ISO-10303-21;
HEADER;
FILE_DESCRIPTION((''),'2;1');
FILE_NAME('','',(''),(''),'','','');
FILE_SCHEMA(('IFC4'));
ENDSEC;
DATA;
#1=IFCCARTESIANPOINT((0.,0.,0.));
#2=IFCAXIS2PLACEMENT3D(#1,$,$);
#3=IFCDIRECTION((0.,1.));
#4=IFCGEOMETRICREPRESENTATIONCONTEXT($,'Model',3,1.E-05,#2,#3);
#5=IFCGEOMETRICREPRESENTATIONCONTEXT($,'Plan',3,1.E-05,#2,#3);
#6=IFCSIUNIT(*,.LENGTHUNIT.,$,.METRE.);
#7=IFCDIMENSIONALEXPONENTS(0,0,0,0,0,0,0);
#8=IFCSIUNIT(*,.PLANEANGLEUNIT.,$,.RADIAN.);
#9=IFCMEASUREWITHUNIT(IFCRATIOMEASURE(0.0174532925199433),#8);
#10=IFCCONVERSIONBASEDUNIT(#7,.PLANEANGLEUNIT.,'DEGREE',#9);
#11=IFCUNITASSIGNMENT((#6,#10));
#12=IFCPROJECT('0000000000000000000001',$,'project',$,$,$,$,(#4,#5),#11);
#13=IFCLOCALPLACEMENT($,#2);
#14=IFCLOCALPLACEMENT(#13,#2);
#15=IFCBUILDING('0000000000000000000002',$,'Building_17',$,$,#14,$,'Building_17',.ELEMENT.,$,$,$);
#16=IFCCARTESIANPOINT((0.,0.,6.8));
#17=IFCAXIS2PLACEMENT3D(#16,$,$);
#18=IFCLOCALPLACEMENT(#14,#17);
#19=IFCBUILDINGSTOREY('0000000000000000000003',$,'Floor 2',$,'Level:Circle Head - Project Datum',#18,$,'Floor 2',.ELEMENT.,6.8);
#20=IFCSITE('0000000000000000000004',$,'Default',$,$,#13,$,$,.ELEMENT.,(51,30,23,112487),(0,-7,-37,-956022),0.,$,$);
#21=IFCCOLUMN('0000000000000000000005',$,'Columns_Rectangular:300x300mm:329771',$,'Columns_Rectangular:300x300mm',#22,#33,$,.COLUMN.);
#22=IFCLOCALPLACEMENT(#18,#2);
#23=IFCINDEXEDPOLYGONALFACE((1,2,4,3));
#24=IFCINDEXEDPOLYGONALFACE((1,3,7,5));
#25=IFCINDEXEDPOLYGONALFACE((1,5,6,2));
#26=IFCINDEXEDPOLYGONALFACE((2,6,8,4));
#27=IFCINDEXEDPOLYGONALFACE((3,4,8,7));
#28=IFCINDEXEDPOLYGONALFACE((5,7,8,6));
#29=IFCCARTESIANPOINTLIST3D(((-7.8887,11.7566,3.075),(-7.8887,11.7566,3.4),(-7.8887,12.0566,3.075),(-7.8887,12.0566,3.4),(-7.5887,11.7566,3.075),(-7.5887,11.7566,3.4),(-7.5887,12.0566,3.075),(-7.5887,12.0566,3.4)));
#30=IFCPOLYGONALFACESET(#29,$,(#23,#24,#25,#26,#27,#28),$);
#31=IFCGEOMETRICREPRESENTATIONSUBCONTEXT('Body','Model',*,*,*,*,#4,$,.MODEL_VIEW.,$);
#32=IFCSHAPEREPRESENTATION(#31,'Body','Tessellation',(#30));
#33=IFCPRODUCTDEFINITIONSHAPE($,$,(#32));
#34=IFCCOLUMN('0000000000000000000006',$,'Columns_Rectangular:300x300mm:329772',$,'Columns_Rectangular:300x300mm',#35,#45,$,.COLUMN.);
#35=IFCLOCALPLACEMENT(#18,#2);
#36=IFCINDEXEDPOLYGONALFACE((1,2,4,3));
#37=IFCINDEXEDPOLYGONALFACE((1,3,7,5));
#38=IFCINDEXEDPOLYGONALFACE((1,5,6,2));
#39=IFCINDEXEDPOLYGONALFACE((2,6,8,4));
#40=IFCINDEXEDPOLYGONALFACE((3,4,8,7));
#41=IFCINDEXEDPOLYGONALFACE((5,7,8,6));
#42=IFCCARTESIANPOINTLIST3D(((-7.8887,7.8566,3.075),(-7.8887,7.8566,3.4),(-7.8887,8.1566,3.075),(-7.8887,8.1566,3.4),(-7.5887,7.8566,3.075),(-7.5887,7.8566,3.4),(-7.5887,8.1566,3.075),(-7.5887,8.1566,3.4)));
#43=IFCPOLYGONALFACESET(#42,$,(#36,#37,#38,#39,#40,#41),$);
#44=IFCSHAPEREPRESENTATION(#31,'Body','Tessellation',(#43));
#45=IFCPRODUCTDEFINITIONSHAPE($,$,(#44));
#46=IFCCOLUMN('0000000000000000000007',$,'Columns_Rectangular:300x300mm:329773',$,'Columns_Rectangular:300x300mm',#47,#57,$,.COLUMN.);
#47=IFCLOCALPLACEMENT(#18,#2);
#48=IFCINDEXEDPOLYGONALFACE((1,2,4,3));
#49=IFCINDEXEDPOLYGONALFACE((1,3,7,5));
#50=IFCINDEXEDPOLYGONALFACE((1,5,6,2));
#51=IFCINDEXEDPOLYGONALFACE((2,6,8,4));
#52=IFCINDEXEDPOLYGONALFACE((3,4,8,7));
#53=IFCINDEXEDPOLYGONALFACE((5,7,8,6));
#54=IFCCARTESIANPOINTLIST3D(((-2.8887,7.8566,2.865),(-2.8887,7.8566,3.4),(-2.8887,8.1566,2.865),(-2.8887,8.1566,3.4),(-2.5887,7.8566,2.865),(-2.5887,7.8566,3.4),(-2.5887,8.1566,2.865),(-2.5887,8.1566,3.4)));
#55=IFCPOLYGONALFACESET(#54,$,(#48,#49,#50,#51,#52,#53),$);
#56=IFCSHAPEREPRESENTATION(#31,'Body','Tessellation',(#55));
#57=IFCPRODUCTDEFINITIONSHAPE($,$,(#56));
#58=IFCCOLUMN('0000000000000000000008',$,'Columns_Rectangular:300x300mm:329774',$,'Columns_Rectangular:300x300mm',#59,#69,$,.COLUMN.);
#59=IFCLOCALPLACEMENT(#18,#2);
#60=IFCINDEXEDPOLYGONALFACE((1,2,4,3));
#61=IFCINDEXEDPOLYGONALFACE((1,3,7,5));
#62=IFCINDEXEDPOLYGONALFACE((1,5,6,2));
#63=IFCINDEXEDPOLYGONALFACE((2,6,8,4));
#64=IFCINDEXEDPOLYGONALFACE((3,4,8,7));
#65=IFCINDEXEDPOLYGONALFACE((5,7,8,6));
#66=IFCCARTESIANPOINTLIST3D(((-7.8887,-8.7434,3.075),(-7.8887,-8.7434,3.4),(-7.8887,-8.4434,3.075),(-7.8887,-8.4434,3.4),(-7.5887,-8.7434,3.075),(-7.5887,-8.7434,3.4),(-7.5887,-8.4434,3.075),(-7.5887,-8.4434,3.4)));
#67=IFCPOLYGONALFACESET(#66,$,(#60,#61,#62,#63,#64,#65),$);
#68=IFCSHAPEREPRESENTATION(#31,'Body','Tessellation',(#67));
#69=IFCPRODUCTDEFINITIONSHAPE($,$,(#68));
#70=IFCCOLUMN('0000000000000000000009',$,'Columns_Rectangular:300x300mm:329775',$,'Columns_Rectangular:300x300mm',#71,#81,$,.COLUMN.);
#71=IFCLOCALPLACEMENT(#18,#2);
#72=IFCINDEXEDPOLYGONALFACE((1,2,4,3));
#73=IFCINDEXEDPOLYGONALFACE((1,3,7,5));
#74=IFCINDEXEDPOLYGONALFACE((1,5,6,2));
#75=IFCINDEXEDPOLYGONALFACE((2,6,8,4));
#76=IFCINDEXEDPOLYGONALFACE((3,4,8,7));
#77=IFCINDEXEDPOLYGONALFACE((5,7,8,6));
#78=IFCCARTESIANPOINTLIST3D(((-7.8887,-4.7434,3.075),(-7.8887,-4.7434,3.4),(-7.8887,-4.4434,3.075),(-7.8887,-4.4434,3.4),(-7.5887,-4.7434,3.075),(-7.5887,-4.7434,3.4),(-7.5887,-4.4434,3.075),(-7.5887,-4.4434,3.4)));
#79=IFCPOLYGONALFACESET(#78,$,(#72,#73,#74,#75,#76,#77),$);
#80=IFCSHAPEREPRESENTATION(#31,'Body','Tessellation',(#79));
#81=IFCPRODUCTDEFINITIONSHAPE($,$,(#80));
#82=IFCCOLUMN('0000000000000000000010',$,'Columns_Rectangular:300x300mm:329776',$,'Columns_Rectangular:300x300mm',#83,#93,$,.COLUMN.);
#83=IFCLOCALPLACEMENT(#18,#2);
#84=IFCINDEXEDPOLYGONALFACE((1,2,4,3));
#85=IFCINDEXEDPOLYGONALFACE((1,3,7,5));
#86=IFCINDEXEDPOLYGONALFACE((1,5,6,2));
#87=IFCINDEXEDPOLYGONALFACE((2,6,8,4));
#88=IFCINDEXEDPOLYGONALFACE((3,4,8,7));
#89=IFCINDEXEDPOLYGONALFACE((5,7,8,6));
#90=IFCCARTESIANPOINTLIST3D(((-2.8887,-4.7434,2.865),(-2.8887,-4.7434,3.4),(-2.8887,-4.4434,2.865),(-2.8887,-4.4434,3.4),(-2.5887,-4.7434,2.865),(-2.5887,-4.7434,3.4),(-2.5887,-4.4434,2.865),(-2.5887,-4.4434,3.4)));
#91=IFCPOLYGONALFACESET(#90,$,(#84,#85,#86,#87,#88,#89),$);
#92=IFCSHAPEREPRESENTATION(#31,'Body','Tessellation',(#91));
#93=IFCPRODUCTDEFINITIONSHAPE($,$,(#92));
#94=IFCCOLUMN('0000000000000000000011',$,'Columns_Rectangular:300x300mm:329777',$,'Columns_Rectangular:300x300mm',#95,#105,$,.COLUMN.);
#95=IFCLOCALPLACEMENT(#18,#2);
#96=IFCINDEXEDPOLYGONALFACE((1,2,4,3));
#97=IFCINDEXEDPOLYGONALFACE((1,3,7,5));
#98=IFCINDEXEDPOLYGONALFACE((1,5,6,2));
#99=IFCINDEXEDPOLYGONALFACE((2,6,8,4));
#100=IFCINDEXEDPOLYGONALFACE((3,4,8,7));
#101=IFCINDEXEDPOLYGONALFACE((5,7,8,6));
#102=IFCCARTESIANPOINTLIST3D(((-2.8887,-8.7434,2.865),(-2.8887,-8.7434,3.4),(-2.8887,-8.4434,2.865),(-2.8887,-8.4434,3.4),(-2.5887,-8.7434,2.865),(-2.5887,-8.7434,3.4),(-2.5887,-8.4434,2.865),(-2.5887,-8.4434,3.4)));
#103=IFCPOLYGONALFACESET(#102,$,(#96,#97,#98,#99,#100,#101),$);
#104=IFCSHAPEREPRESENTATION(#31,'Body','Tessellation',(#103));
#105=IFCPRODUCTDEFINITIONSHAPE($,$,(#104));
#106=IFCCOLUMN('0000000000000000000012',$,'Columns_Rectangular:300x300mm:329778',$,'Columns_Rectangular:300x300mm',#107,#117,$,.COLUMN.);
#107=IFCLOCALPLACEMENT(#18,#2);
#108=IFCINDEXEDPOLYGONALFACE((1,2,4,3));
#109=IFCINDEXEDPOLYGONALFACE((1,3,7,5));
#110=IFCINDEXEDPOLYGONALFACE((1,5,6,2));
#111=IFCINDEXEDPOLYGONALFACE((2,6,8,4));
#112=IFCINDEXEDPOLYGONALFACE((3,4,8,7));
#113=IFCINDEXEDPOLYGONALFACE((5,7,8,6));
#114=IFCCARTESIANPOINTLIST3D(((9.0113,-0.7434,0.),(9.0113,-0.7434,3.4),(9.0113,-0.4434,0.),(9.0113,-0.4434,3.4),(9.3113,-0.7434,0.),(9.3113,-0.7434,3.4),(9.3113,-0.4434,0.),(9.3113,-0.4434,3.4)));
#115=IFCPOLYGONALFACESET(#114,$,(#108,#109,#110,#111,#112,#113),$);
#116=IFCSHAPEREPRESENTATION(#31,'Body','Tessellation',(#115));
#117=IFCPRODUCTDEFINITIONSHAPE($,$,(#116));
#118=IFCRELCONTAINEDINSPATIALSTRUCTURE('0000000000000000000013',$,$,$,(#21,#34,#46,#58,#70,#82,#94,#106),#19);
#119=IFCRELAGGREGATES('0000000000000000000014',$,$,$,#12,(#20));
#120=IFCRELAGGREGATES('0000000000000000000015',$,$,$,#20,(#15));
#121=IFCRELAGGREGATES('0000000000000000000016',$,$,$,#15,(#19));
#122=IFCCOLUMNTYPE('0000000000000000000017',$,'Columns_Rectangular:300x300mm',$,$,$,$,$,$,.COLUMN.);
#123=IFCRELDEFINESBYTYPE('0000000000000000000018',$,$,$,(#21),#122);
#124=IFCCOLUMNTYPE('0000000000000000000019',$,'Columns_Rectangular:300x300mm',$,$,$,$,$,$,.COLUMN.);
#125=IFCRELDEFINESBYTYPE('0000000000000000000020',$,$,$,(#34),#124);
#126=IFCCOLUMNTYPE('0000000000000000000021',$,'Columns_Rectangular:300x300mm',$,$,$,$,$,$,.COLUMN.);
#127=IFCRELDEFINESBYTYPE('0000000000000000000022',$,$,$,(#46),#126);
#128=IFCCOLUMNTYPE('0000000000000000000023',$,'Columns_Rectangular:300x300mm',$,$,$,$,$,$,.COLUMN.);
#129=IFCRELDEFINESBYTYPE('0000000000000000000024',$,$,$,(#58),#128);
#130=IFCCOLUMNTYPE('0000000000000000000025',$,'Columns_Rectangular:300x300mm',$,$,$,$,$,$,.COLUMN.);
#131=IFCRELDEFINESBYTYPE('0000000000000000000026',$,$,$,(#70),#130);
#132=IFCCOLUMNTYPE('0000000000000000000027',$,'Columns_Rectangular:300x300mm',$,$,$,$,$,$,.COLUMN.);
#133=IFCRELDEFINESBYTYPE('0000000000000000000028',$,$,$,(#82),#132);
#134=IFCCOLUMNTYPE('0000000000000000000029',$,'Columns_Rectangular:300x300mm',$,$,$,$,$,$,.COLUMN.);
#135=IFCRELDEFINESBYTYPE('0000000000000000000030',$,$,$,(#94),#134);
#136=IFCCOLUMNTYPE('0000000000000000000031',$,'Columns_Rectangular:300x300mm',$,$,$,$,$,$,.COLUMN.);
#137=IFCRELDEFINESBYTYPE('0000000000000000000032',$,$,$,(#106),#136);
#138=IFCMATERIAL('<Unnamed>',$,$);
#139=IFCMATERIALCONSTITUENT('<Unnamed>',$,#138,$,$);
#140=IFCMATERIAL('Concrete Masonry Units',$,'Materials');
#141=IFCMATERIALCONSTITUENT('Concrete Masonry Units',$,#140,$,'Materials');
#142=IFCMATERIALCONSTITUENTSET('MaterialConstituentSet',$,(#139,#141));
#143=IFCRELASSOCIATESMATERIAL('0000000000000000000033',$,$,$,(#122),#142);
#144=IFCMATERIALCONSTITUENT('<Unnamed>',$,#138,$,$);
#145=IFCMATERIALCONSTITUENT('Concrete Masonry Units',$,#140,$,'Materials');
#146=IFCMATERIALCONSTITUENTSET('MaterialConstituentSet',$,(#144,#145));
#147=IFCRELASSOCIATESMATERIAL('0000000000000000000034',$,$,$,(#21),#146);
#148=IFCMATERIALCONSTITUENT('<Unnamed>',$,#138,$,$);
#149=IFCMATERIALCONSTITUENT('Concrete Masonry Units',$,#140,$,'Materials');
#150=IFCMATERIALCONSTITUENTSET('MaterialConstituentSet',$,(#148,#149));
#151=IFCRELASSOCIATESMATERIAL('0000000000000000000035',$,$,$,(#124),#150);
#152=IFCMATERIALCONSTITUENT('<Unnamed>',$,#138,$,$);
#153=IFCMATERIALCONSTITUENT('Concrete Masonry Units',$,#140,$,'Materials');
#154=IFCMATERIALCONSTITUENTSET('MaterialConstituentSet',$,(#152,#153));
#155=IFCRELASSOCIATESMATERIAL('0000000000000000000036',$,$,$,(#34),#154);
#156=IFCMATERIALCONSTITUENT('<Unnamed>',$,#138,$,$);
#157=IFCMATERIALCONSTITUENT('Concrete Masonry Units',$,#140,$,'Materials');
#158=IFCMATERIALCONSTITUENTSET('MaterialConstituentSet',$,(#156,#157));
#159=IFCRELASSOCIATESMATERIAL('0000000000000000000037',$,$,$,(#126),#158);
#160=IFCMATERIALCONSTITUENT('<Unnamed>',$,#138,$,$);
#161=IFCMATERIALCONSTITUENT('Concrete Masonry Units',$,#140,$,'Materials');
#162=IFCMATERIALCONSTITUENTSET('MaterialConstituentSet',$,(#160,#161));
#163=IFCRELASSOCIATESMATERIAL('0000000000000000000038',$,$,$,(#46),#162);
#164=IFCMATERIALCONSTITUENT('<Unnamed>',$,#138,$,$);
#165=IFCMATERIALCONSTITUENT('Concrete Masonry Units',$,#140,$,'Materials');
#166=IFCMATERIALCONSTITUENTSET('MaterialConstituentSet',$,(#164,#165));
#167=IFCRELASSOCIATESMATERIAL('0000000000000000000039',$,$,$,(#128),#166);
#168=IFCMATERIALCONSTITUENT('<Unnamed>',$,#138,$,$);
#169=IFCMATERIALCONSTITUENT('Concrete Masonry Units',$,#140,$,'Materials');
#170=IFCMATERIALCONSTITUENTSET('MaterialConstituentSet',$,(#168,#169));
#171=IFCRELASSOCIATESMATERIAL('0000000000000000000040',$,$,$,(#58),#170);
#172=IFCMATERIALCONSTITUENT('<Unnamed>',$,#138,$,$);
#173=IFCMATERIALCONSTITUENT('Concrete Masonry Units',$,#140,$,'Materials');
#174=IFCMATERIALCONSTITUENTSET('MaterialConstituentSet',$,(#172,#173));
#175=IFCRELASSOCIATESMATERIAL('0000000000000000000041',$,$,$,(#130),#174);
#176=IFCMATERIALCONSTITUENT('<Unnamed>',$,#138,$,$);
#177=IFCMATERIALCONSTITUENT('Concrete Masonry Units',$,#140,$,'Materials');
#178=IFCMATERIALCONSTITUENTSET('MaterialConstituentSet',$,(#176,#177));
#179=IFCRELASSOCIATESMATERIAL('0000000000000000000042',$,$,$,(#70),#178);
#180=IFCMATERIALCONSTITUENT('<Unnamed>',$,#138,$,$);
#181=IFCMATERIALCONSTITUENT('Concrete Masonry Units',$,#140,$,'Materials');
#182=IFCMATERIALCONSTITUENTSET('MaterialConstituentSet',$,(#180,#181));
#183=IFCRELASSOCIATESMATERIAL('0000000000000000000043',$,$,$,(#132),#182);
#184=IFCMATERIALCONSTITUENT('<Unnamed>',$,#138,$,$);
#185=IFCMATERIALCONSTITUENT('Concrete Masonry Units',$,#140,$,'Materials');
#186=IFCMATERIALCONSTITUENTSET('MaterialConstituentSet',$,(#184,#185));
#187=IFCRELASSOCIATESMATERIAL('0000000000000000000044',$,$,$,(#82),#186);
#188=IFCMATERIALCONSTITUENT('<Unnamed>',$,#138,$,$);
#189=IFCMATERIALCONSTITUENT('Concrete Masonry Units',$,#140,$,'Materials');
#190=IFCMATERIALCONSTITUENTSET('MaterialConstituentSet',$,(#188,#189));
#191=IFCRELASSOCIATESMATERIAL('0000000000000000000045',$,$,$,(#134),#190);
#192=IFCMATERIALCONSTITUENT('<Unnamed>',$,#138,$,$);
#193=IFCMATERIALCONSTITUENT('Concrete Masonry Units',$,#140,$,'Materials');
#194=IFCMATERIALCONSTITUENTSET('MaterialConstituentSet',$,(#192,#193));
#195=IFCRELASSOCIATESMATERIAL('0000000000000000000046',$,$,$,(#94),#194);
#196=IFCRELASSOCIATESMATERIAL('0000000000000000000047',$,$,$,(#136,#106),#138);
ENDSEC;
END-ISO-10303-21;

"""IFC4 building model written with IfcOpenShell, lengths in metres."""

from ifc_helpers import new_model, entity, si_unit, converted_unit, direction, frame, origin, place, context, subcontext, project, spatial, indexed_curve, outline, extrude, source, transform, mapped, material, constituent, constituent_set, type_object, type_shapes, element, save


model = new_model("IFC4")

# Units and contexts
model_context = context("Model", 3, precision=1e-05, world=origin(), true_north=direction((0.0, 1.0)))
plan_context = context("Plan", 3, precision=1e-05, world=origin(), true_north=direction((0.0, 1.0)))
body_context = subcontext(model_context, "Body", "Model", "MODEL_VIEW")
ifc_project = project(units=[si_unit("LENGTHUNIT", "METRE"), converted_unit("PLANEANGLEUNIT", "DEGREE", entity("IfcRatioMeasure", 0.0174532925199433), si_unit("PLANEANGLEUNIT", "RADIAN"), dimensions=[0, 0, 0, 0, 0, 0, 0])], contexts=[model_context, plan_context])

# Site, building, storey
site_placement = place(None, origin())
site = spatial("IfcSite", under=ifc_project, at=site_placement, Name="Default", CompositionType="ELEMENT", RefLatitude=(51, 30, 23, 112487), RefLongitude=(0, -7, -37, -956022), RefElevation=0.0)
building_placement = place(site_placement, origin())
building = spatial("IfcBuilding", under=site, at=building_placement, Name="Building_17", LongName="Building_17", CompositionType="ELEMENT")
storey_placement = place(building_placement, frame((0.0, 0.0, 6.8)))
storey = spatial("IfcBuildingStorey", under=building, at=storey_placement, Name="Floor 2", ObjectType="Level:Circle Head - Project Datum", LongName="Floor 2", CompositionType="ELEMENT", Elevation=6.8)

# Columns
ifc_material_1 = material(Name="<Unnamed>")
ifc_material_2 = material(Name="Concrete Masonry Units", Category="Materials")
ifc_constituent_1 = constituent(ifc_material_1, Name="<Unnamed>")
ifc_constituent_2 = constituent(ifc_material_2, Name="Concrete Masonry Units", Category="Materials")
ifc_constituent_set_1 = constituent_set(constituents=[ifc_constituent_1, ifc_constituent_2], Name="MaterialConstituentSet")
ifc_constituent_3 = constituent(ifc_material_1, Name="<Unnamed>")
ifc_constituent_4 = constituent(ifc_material_2, Name="Concrete Masonry Units", Category="Materials")
ifc_constituent_set_2 = constituent_set(constituents=[ifc_constituent_3, ifc_constituent_4], Name="MaterialConstituentSet")
column_type_1 = type_object("IfcColumnType", Name="Columns_Rectangular:300x300mm", PredefinedType="COLUMN", material=ifc_constituent_set_2)
shared_shape_1 = source(origin(), body_context, "Body", "SweptSolid", [
    extrude(outline(indexed_curve([(-0.15, -0.15), (0.15, -0.15), (0.15, 0.15), (-0.15, 0.15), (-0.15, -0.15)], self_intersect=False)), frame((-7.7387, 11.9066, 9.875), z_axis=(0.0, 0.0, 1.0), x_axis=(0.0, -1.0, 0.0)), (0.0, 0.0, 1.0), 0.325),
])
type_shapes(column_type_1, [shared_shape_1])
column_1_placement = place(storey_placement, frame((0.0, 0.0, -6.8)))
element("IfcColumn", 1, at=column_1_placement, inside=storey, type_object=column_type_1, material=ifc_constituent_set_1, Name="Columns_Rectangular:300x300mm:329771", ObjectType="Columns_Rectangular:300x300mm", PredefinedType="COLUMN", context=body_context, shape_type="MappedRepresentation", body=[
    mapped(shared_shape_1, transform((0.0, 0.0, 0.0), scale=1.0)),
])
ifc_constituent_5 = constituent(ifc_material_1, Name="<Unnamed>")
ifc_constituent_6 = constituent(ifc_material_2, Name="Concrete Masonry Units", Category="Materials")
ifc_constituent_set_3 = constituent_set(constituents=[ifc_constituent_5, ifc_constituent_6], Name="MaterialConstituentSet")
ifc_constituent_7 = constituent(ifc_material_1, Name="<Unnamed>")
ifc_constituent_8 = constituent(ifc_material_2, Name="Concrete Masonry Units", Category="Materials")
ifc_constituent_set_4 = constituent_set(constituents=[ifc_constituent_7, ifc_constituent_8], Name="MaterialConstituentSet")
column_type_2 = type_object("IfcColumnType", Name="Columns_Rectangular:300x300mm", PredefinedType="COLUMN", material=ifc_constituent_set_4)
shared_shape_2 = source(origin(), body_context, "Body", "SweptSolid", [
    extrude(outline(indexed_curve([(-0.15, -0.15), (0.15, -0.15), (0.15, 0.15), (-0.15, 0.15), (-0.15, -0.15)], self_intersect=False)), frame((-7.7387, 8.0066, 9.875), z_axis=(0.0, 0.0, 1.0), x_axis=(0.0, -1.0, 0.0)), (0.0, 0.0, 1.0), 0.325),
])
type_shapes(column_type_2, [shared_shape_2])
column_2_placement = place(storey_placement, frame((0.0, 0.0, -6.8)))
element("IfcColumn", 2, at=column_2_placement, inside=storey, type_object=column_type_2, material=ifc_constituent_set_3, Name="Columns_Rectangular:300x300mm:329772", ObjectType="Columns_Rectangular:300x300mm", PredefinedType="COLUMN", context=body_context, shape_type="MappedRepresentation", body=[
    mapped(shared_shape_2, transform((0.0, 0.0, 0.0), scale=1.0)),
])
ifc_constituent_9 = constituent(ifc_material_1, Name="<Unnamed>")
ifc_constituent_10 = constituent(ifc_material_2, Name="Concrete Masonry Units", Category="Materials")
ifc_constituent_set_5 = constituent_set(constituents=[ifc_constituent_9, ifc_constituent_10], Name="MaterialConstituentSet")
ifc_constituent_11 = constituent(ifc_material_1, Name="<Unnamed>")
ifc_constituent_12 = constituent(ifc_material_2, Name="Concrete Masonry Units", Category="Materials")
ifc_constituent_set_6 = constituent_set(constituents=[ifc_constituent_11, ifc_constituent_12], Name="MaterialConstituentSet")
column_type_3 = type_object("IfcColumnType", Name="Columns_Rectangular:300x300mm", PredefinedType="COLUMN", material=ifc_constituent_set_6)
shared_shape_3 = source(origin(), body_context, "Body", "SweptSolid", [
    extrude(outline(indexed_curve([(-0.15, -0.15), (0.15, -0.15), (0.15, 0.15), (-0.15, 0.15), (-0.15, -0.15)], self_intersect=False)), frame((-2.7387, 8.0066, 9.665), z_axis=(0.0, 0.0, 1.0), x_axis=(0.0, -1.0, 0.0)), (0.0, 0.0, 1.0), 0.535),
])
type_shapes(column_type_3, [shared_shape_3])
column_3_placement = place(storey_placement, frame((0.0, 0.0, -6.8)))
element("IfcColumn", 3, at=column_3_placement, inside=storey, type_object=column_type_3, material=ifc_constituent_set_5, Name="Columns_Rectangular:300x300mm:329773", ObjectType="Columns_Rectangular:300x300mm", PredefinedType="COLUMN", context=body_context, shape_type="MappedRepresentation", body=[
    mapped(shared_shape_3, transform((0.0, 0.0, 0.0), scale=1.0)),
])
ifc_constituent_13 = constituent(ifc_material_1, Name="<Unnamed>")
ifc_constituent_14 = constituent(ifc_material_2, Name="Concrete Masonry Units", Category="Materials")
ifc_constituent_set_7 = constituent_set(constituents=[ifc_constituent_13, ifc_constituent_14], Name="MaterialConstituentSet")
ifc_constituent_15 = constituent(ifc_material_1, Name="<Unnamed>")
ifc_constituent_16 = constituent(ifc_material_2, Name="Concrete Masonry Units", Category="Materials")
ifc_constituent_set_8 = constituent_set(constituents=[ifc_constituent_15, ifc_constituent_16], Name="MaterialConstituentSet")
column_type_4 = type_object("IfcColumnType", Name="Columns_Rectangular:300x300mm", PredefinedType="COLUMN", material=ifc_constituent_set_8)
shared_shape_4 = source(origin(), body_context, "Body", "SweptSolid", [
    extrude(outline(indexed_curve([(-0.15, -0.15), (0.15, -0.15), (0.15, 0.15), (-0.15, 0.15), (-0.15, -0.15)], self_intersect=False)), frame((-7.7387, -8.5934, 9.875), z_axis=(0.0, 0.0, 1.0), x_axis=(0.0, -1.0, 0.0)), (0.0, 0.0, 1.0), 0.325),
])
type_shapes(column_type_4, [shared_shape_4])
column_4_placement = place(storey_placement, frame((0.0, 0.0, -6.8)))
element("IfcColumn", 4, at=column_4_placement, inside=storey, type_object=column_type_4, material=ifc_constituent_set_7, Name="Columns_Rectangular:300x300mm:329774", ObjectType="Columns_Rectangular:300x300mm", PredefinedType="COLUMN", context=body_context, shape_type="MappedRepresentation", body=[
    mapped(shared_shape_4, transform((0.0, 0.0, 0.0), scale=1.0)),
])
ifc_constituent_17 = constituent(ifc_material_1, Name="<Unnamed>")
ifc_constituent_18 = constituent(ifc_material_2, Name="Concrete Masonry Units", Category="Materials")
ifc_constituent_set_9 = constituent_set(constituents=[ifc_constituent_17, ifc_constituent_18], Name="MaterialConstituentSet")
ifc_constituent_19 = constituent(ifc_material_1, Name="<Unnamed>")
ifc_constituent_20 = constituent(ifc_material_2, Name="Concrete Masonry Units", Category="Materials")
ifc_constituent_set_10 = constituent_set(constituents=[ifc_constituent_19, ifc_constituent_20], Name="MaterialConstituentSet")
column_type_5 = type_object("IfcColumnType", Name="Columns_Rectangular:300x300mm", PredefinedType="COLUMN", material=ifc_constituent_set_10)
shared_shape_5 = source(origin(), body_context, "Body", "SweptSolid", [
    extrude(outline(indexed_curve([(-0.15, -0.15), (0.15, -0.15), (0.15, 0.15), (-0.15, 0.15), (-0.15, -0.15)], self_intersect=False)), frame((-7.7387, -4.5934, 9.875), z_axis=(0.0, 0.0, 1.0), x_axis=(0.0, -1.0, 0.0)), (0.0, 0.0, 1.0), 0.325),
])
type_shapes(column_type_5, [shared_shape_5])
column_5_placement = place(storey_placement, frame((0.0, 0.0, -6.8)))
element("IfcColumn", 5, at=column_5_placement, inside=storey, type_object=column_type_5, material=ifc_constituent_set_9, Name="Columns_Rectangular:300x300mm:329775", ObjectType="Columns_Rectangular:300x300mm", PredefinedType="COLUMN", context=body_context, shape_type="MappedRepresentation", body=[
    mapped(shared_shape_5, transform((0.0, 0.0, 0.0), scale=1.0)),
])
ifc_constituent_21 = constituent(ifc_material_1, Name="<Unnamed>")
ifc_constituent_22 = constituent(ifc_material_2, Name="Concrete Masonry Units", Category="Materials")
ifc_constituent_set_11 = constituent_set(constituents=[ifc_constituent_21, ifc_constituent_22], Name="MaterialConstituentSet")
ifc_constituent_23 = constituent(ifc_material_1, Name="<Unnamed>")
ifc_constituent_24 = constituent(ifc_material_2, Name="Concrete Masonry Units", Category="Materials")
ifc_constituent_set_12 = constituent_set(constituents=[ifc_constituent_23, ifc_constituent_24], Name="MaterialConstituentSet")
column_type_6 = type_object("IfcColumnType", Name="Columns_Rectangular:300x300mm", PredefinedType="COLUMN", material=ifc_constituent_set_12)
shared_shape_6 = source(origin(), body_context, "Body", "SweptSolid", [
    extrude(outline(indexed_curve([(-0.15, -0.15), (0.15, -0.15), (0.15, 0.15), (-0.15, 0.15), (-0.15, -0.15)], self_intersect=False)), frame((-2.7387, -4.5934, 9.665), z_axis=(0.0, 0.0, 1.0), x_axis=(0.0, -1.0, 0.0)), (0.0, 0.0, 1.0), 0.535),
])
type_shapes(column_type_6, [shared_shape_6])
column_6_placement = place(storey_placement, frame((0.0, 0.0, -6.8)))
element("IfcColumn", 6, at=column_6_placement, inside=storey, type_object=column_type_6, material=ifc_constituent_set_11, Name="Columns_Rectangular:300x300mm:329776", ObjectType="Columns_Rectangular:300x300mm", PredefinedType="COLUMN", context=body_context, shape_type="MappedRepresentation", body=[
    mapped(shared_shape_6, transform((0.0, 0.0, 0.0), scale=1.0)),
])
ifc_constituent_25 = constituent(ifc_material_1, Name="<Unnamed>")
ifc_constituent_26 = constituent(ifc_material_2, Name="Concrete Masonry Units", Category="Materials")
ifc_constituent_set_13 = constituent_set(constituents=[ifc_constituent_25, ifc_constituent_26], Name="MaterialConstituentSet")
ifc_constituent_27 = constituent(ifc_material_1, Name="<Unnamed>")
ifc_constituent_28 = constituent(ifc_material_2, Name="Concrete Masonry Units", Category="Materials")
ifc_constituent_set_14 = constituent_set(constituents=[ifc_constituent_27, ifc_constituent_28], Name="MaterialConstituentSet")
column_type_7 = type_object("IfcColumnType", Name="Columns_Rectangular:300x300mm", PredefinedType="COLUMN", material=ifc_constituent_set_14)
shared_shape_7 = source(origin(), body_context, "Body", "SweptSolid", [
    extrude(outline(indexed_curve([(-0.15, -0.15), (0.15, -0.15), (0.15, 0.15), (-0.15, 0.15), (-0.15, -0.15)], self_intersect=False)), frame((-2.7387, -8.5934, 9.665), z_axis=(0.0, 0.0, 1.0), x_axis=(0.0, -1.0, 0.0)), (0.0, 0.0, 1.0), 0.535),
])
type_shapes(column_type_7, [shared_shape_7])
column_7_placement = place(storey_placement, frame((0.0, 0.0, -6.8)))
element("IfcColumn", 7, at=column_7_placement, inside=storey, type_object=column_type_7, material=ifc_constituent_set_13, Name="Columns_Rectangular:300x300mm:329777", ObjectType="Columns_Rectangular:300x300mm", PredefinedType="COLUMN", context=body_context, shape_type="MappedRepresentation", body=[
    mapped(shared_shape_7, transform((0.0, 0.0, 0.0), scale=1.0)),
])
column_type_8 = type_object("IfcColumnType", Name="Columns_Rectangular:300x300mm", PredefinedType="COLUMN", material=ifc_material_1)
shared_shape_8 = source(origin(), body_context, "Body", "SweptSolid", [
    extrude(outline(indexed_curve([(-0.15, -0.15), (0.15, -0.15), (0.15, 0.15), (-0.15, 0.15), (-0.15, -0.15)], self_intersect=False)), frame((9.1613, -0.5934, 6.8), z_axis=(0.0, 0.0, 1.0), x_axis=(0.0, -1.0, 0.0)), (0.0, 0.0, 1.0), 3.4),
])
type_shapes(column_type_8, [shared_shape_8])
column_8_placement = place(storey_placement, frame((0.0, 0.0, -6.8)))
element("IfcColumn", 8, at=column_8_placement, inside=storey, type_object=column_type_8, material=ifc_material_1, Name="Columns_Rectangular:300x300mm:329778", ObjectType="Columns_Rectangular:300x300mm", PredefinedType="COLUMN", context=body_context, shape_type="MappedRepresentation", body=[
    mapped(shared_shape_8, transform((0.0, 0.0, 0.0), scale=1.0)),
])

save(model, "model.ifc")
